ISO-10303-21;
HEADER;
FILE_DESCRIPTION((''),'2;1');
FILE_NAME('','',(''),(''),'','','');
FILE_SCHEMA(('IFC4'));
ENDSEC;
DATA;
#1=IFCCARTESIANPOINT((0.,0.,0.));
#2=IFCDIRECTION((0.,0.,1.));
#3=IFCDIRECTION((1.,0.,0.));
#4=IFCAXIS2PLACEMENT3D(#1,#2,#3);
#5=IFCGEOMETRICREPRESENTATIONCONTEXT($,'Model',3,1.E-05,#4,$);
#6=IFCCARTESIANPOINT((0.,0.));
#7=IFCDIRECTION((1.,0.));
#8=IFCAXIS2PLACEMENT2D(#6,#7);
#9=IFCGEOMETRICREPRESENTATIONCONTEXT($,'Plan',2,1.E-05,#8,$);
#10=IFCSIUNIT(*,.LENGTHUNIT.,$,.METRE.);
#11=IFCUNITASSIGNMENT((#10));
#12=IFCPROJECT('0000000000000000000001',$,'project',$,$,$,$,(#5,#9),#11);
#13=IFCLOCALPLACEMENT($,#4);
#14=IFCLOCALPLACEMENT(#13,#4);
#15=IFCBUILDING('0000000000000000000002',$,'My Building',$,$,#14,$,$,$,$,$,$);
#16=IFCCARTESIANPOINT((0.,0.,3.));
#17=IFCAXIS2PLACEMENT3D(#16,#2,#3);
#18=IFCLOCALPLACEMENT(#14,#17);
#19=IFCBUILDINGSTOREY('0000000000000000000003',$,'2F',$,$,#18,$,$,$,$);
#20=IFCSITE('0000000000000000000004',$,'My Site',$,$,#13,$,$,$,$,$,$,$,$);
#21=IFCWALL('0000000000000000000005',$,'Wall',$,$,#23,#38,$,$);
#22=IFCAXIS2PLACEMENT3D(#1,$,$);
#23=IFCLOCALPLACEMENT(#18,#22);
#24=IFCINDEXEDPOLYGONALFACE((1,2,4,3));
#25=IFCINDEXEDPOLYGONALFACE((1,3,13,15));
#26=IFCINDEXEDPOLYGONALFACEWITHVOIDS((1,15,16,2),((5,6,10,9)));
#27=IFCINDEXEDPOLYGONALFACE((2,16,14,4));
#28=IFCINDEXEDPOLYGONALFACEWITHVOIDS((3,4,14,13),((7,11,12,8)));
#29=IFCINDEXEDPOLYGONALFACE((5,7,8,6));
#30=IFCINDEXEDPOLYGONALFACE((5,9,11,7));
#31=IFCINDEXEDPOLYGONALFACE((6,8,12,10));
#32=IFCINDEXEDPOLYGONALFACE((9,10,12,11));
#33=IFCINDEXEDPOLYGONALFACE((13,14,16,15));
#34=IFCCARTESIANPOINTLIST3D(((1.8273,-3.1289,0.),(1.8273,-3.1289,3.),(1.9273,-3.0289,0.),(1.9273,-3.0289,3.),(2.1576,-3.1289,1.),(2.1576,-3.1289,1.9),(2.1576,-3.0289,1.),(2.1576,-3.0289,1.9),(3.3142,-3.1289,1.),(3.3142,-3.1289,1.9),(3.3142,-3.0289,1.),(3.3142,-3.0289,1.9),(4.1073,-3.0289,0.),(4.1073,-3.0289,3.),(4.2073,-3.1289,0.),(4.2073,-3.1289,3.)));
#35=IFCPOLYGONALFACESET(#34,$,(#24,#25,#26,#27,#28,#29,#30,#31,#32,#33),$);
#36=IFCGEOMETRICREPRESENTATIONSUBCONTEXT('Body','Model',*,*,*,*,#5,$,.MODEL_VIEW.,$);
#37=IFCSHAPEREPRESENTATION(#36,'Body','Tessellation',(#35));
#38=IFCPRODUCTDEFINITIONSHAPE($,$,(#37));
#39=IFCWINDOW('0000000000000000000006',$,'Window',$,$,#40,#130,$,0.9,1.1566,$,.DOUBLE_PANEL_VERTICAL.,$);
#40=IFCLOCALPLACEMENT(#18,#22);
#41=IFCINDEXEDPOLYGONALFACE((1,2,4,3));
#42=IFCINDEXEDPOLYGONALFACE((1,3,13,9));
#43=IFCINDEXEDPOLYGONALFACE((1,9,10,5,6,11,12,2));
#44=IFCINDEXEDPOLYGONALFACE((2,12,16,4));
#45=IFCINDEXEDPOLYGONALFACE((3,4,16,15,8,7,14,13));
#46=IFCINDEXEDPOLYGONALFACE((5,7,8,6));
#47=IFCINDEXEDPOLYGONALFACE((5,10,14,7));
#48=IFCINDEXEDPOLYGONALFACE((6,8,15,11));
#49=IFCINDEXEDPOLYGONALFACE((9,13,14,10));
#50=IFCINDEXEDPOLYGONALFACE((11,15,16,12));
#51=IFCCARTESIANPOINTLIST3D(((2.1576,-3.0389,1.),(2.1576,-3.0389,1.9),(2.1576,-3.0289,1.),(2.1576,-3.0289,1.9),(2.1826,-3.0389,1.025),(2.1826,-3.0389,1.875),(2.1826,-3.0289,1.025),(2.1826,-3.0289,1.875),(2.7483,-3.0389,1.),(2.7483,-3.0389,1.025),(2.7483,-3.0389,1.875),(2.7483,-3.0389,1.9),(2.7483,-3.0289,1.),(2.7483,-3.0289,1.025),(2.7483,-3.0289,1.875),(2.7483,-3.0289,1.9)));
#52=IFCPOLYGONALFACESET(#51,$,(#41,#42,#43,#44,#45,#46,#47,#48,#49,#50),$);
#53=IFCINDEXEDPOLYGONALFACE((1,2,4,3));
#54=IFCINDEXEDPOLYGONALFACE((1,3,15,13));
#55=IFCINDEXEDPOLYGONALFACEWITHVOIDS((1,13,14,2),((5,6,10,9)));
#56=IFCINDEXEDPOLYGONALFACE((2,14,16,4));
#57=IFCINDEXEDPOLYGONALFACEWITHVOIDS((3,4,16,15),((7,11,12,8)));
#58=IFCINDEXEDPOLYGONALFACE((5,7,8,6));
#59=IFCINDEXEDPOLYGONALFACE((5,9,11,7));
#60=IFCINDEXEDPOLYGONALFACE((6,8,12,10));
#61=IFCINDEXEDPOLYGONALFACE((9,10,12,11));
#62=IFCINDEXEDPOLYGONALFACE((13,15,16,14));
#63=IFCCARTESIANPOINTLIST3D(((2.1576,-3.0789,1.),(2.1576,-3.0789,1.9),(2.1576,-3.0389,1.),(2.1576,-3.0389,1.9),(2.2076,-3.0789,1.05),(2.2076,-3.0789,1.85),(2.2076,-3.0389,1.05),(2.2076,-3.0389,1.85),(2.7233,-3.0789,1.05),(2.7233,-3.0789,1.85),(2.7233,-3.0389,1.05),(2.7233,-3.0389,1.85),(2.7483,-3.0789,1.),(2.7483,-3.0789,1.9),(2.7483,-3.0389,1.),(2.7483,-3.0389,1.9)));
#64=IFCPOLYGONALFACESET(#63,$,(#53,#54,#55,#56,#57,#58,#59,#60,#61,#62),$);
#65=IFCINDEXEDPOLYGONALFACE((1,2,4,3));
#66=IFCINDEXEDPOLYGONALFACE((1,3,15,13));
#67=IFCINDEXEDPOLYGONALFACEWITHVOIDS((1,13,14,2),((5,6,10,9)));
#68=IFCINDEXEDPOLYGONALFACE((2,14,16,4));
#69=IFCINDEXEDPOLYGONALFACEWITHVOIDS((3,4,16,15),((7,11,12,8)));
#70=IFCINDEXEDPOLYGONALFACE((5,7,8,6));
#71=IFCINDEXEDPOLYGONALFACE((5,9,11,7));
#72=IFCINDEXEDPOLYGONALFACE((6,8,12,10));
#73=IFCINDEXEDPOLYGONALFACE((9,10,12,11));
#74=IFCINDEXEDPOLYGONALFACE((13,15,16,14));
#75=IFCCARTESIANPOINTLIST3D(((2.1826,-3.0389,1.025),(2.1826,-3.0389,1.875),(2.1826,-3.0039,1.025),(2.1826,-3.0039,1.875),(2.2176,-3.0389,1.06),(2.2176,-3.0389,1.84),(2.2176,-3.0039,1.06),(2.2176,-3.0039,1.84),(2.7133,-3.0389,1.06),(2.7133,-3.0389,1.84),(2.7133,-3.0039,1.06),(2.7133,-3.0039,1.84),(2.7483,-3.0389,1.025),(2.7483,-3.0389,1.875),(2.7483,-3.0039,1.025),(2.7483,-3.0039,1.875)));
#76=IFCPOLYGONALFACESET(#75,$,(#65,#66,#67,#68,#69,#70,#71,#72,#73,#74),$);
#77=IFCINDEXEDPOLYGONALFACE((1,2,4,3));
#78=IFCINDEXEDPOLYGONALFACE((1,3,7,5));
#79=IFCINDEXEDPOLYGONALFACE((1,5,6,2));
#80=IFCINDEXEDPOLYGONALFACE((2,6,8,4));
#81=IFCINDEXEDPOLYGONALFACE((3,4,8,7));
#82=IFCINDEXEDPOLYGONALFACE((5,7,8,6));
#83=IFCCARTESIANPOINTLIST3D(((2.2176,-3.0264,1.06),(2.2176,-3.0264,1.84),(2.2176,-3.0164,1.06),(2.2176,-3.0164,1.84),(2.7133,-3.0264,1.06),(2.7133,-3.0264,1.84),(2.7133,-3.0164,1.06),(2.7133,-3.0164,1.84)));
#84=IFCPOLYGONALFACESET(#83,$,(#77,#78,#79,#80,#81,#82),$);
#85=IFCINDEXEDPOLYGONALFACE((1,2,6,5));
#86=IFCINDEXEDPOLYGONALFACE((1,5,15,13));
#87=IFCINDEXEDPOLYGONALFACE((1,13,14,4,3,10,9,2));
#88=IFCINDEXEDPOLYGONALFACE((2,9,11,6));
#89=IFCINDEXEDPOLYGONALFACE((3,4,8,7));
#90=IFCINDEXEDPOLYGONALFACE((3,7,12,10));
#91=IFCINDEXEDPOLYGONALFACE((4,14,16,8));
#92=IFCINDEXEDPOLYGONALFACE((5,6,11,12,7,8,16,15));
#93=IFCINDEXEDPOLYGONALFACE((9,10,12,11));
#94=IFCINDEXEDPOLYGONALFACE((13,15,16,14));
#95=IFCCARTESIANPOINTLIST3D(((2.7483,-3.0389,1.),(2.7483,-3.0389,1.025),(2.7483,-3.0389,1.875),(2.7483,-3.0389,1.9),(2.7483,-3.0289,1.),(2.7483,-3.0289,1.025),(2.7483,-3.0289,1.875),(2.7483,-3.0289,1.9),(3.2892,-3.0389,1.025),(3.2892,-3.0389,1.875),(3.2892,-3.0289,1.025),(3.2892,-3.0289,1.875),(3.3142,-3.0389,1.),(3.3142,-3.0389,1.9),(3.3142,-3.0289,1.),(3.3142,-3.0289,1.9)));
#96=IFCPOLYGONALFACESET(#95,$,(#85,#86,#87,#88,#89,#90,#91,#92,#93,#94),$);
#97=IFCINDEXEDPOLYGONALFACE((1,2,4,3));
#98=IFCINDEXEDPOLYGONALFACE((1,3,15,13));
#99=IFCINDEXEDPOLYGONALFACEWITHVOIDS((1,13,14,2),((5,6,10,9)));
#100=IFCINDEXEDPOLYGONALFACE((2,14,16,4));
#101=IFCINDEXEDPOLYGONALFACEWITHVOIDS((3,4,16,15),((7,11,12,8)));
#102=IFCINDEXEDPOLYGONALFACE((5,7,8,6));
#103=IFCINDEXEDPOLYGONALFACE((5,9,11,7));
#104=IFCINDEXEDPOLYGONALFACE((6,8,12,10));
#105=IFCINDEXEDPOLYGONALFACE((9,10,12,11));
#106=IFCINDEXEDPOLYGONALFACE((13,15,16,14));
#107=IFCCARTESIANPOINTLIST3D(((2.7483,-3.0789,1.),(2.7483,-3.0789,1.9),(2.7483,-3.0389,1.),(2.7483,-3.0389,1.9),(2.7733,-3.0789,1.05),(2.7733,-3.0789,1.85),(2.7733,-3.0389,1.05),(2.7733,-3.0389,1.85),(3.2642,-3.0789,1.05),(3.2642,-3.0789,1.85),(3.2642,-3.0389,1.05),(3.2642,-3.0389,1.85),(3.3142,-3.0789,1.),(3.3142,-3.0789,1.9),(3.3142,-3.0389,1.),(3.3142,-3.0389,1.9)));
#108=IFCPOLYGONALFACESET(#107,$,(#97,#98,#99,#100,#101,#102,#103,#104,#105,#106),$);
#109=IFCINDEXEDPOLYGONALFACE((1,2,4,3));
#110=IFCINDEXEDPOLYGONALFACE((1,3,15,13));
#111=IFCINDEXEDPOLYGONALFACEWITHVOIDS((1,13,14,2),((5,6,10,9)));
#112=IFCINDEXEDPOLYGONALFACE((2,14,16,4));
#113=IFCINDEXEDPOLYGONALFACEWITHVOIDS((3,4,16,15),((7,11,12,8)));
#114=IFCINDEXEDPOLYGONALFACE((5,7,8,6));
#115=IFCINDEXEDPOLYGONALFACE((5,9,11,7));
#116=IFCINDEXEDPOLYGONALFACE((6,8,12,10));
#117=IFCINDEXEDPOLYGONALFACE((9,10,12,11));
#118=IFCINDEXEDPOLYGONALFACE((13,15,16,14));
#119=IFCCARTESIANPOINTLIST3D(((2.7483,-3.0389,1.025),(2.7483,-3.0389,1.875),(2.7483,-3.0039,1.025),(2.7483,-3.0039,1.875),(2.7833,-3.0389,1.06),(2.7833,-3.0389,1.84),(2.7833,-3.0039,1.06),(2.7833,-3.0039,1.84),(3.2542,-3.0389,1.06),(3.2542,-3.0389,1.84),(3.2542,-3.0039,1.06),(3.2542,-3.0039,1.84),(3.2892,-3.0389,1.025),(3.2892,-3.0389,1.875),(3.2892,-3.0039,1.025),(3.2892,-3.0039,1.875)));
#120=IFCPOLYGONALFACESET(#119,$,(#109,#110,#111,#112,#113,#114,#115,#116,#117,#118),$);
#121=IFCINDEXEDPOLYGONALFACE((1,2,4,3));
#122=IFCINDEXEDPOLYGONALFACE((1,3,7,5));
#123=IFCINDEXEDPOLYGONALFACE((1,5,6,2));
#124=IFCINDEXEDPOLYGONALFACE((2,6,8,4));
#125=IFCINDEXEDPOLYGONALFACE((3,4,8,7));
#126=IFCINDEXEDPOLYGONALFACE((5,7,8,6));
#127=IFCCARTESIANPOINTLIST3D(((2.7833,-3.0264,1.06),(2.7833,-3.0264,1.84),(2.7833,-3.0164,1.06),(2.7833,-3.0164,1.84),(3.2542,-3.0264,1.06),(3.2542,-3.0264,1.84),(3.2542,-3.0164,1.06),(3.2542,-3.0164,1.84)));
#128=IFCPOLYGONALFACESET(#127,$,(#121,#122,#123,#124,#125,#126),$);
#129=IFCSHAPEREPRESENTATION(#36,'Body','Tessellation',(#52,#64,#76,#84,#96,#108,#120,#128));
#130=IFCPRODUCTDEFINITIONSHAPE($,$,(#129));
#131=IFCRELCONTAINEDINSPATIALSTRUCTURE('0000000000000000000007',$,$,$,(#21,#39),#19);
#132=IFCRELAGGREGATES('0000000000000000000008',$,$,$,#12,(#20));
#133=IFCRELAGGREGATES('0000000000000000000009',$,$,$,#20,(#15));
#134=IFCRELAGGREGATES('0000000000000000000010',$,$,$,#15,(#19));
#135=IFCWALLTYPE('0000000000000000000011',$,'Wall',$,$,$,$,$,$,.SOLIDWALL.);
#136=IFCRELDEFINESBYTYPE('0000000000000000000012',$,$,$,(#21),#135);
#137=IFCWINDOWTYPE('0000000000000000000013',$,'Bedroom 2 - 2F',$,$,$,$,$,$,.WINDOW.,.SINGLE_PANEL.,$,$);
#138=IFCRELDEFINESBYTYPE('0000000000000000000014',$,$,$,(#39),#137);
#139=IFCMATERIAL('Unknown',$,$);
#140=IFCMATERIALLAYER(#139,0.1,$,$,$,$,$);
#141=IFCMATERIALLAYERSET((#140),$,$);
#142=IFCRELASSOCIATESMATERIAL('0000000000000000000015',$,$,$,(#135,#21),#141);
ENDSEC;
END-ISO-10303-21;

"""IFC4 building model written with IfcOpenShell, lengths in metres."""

from ifc_helpers import new_model, entity, si_unit, frame, origin_with_axes, origin_2d_with_axis, place, context, subcontext, project, spatial, line, indexed_curve, outline, extrude, shape, source, transform, mapped, material, layer, layer_set, layer_usage, type_object, type_shapes, element, fill, save


model = new_model("IFC4")

# Units and contexts
model_context = context("Model", 3, precision=1e-05, world=origin_with_axes())
plan_context = context("Plan", 2, precision=1e-05, world=origin_2d_with_axis())
body_context_1 = subcontext(model_context, "Body", "Model", "MODEL_VIEW")
body_context_2 = subcontext(plan_context, "Body", "Plan", "PLAN_VIEW")
ifc_project = project(units=[si_unit("LENGTHUNIT", "METRE")], contexts=[model_context, plan_context])

# Site, building, storey
site_placement = place(None, origin_with_axes())
site = spatial("IfcSite", under=ifc_project, at=site_placement, Name="My Site")
building_placement = place(site_placement, origin_with_axes())
building = spatial("IfcBuilding", under=site, at=building_placement, Name="My Building")
storey_placement = place(building_placement, frame((0.0, 0.0, 3.0), z_axis=(0.0, 0.0, 1.0), x_axis=(1.0, 0.0, 0.0)))
storey = spatial("IfcBuildingStorey", under=building, at=storey_placement, Name="2F")

# Shared definitions
ifc_material = material(Name="Unknown")

# Shared definitions
ifc_layer_1 = layer(ifc_material, 0.1)
ifc_layer_set_1 = layer_set([ifc_layer_1])
wall_type_1 = type_object("IfcWallType", Name="Wall", PredefinedType="SOLIDWALL", material=ifc_layer_set_1)

# Wall, opening, window
ifc_layer_usage_1 = layer_usage(ifc_layer_set_1, "AXIS2", "POSITIVE", 0.0)
wall_1_placement = place(storey_placement, frame((1.8273, -3.1289, 0.0), z_axis=(0.0, 0.0, 1.0), x_axis=(1.0, 0.0, 0.0)))
wall_1 = element("IfcWall", 1, at=wall_1_placement, inside=storey, type_object=wall_type_1, material=ifc_layer_usage_1, Name="Wall", context=body_context_1, shape_type="SweptSolid", body=[
    extrude(outline(indexed_curve([(0.0, 0.0), (0.1, 0.1), (2.28, 0.1), (2.38, 0.0)], segments=[line(1, 2, 3, 4, 1)])), origin_with_axes(), (0.0, 0.0, 1.0), 3.0),
])
shared_shape_1 = source(origin_with_axes(), body_context_1, "Body", "SweptSolid", [
    extrude(outline(indexed_curve([(0.0, 0.0), (1.1566, 0.0), (1.1566, 0.9), (0.0, 0.9)], segments=[line(1, 2, 3, 4, 1)])), frame((0.0, -0.6, 0.0), z_axis=(0.0, -1.0, 0.0), x_axis=(1.0, 0.0, 0.0)), (0.0, 0.0, -1.0), 1.2),
])
opening_1_placement = place(wall_1_placement, frame((0.3303, 0.0, 1.0), z_axis=(0.0, 0.0, 1.0), x_axis=(1.0, 0.0, 0.0)))
opening_1 = element("IfcOpeningElement", 2, at=opening_1_placement, cuts=wall_1, PredefinedType="OPENING", context=body_context_1, shape_type="MappedRepresentation", body=[
    mapped(shared_shape_1, transform((0.0, 0.0, 0.0), x_axis=(1.0, 0.0, 0.0), y_axis=(0.0, 1.0, 0.0), z_axis=(0.0, 0.0, 1.0), scale=1.0)),
])
window_type = type_object("IfcWindowType", Name="Bedroom 2 - 2F", PartitioningType="SINGLE_PANEL", PredefinedType="WINDOW")
shared_shape_2 = source(origin_with_axes(), body_context_1, "Body", "SweptSolid", [
    extrude(outline(indexed_curve([(0.5908, 0.0), (0.0, 0.0), (0.0, 0.9), (0.5908, 0.9), (0.5908, 0.875), (0.025, 0.875), (0.025, 0.025), (0.5908, 0.025)], segments=[line(1, 2, 3, 4, 5, 6, 7, 8, 1)])), frame((0.0, 0.09, 0.0), z_axis=(0.0, -1.0, 0.0), x_axis=(1.0, 0.0, 0.0)), (0.0, 0.0, -1.0), 0.01),
    extrude(outline(indexed_curve([(0.0, 0.0), (0.5908, 0.0), (0.5908, 0.9), (0.0, 0.9)], segments=[line(1, 2, 3, 4, 1)]), holes=[indexed_curve([(0.05, 0.05), (0.5658, 0.05), (0.5658, 0.85), (0.05, 0.85)], segments=[line(1, 2, 3, 4, 1)])]), frame((0.0, 0.05, 0.0), z_axis=(0.0, -1.0, 0.0), x_axis=(1.0, 0.0, 0.0)), (0.0, 0.0, -1.0), 0.04),
    extrude(outline(indexed_curve([(0.0, 0.0), (0.5658, 0.0), (0.5658, 0.85), (0.0, 0.85)], segments=[line(1, 2, 3, 4, 1)]), holes=[indexed_curve([(0.035, 0.035), (0.5308, 0.035), (0.5308, 0.815), (0.035, 0.815)], segments=[line(1, 2, 3, 4, 1)])]), frame((0.025, 0.09, 0.025), z_axis=(0.0, -1.0, 0.0), x_axis=(1.0, 0.0, 0.0)), (0.0, 0.0, -1.0), 0.035),
    extrude(outline(indexed_curve([(0.035, 0.035), (0.5308, 0.035), (0.5308, 0.815), (0.035, 0.815)], segments=[line(1, 2, 3, 4, 1)])), frame((0.025, 0.1025, 0.025), z_axis=(0.0, -1.0, 0.0), x_axis=(1.0, 0.0, 0.0)), (0.0, 0.0, -1.0), 0.01),
    extrude(outline(indexed_curve([(0.0, 0.9), (0.5659, 0.9), (0.5659, 0.0), (0.0, 0.0), (0.0, 0.025), (0.5409, 0.025), (0.5409, 0.875), (0.0, 0.875)], segments=[line(1, 2, 3, 4, 5, 6, 7, 8, 1)])), frame((0.5908, 0.09, 0.0), z_axis=(0.0, -1.0, 0.0), x_axis=(1.0, 0.0, 0.0)), (0.0, 0.0, -1.0), 0.01),
    extrude(outline(indexed_curve([(0.0, 0.0), (0.5659, 0.0), (0.5659, 0.9), (0.0, 0.9)], segments=[line(1, 2, 3, 4, 1)]), holes=[indexed_curve([(0.025, 0.05), (0.5159, 0.05), (0.5159, 0.85), (0.025, 0.85)], segments=[line(1, 2, 3, 4, 1)])]), frame((0.5908, 0.05, 0.0), z_axis=(0.0, -1.0, 0.0), x_axis=(1.0, 0.0, 0.0)), (0.0, 0.0, -1.0), 0.04),
    extrude(outline(indexed_curve([(0.0, 0.0), (0.5409, 0.0), (0.5409, 0.85), (0.0, 0.85)], segments=[line(1, 2, 3, 4, 1)]), holes=[indexed_curve([(0.035, 0.035), (0.5059, 0.035), (0.5059, 0.815), (0.035, 0.815)], segments=[line(1, 2, 3, 4, 1)])]), frame((0.5908, 0.09, 0.025), z_axis=(0.0, -1.0, 0.0), x_axis=(1.0, 0.0, 0.0)), (0.0, 0.0, -1.0), 0.035),
    extrude(outline(indexed_curve([(0.035, 0.035), (0.5059, 0.035), (0.5059, 0.815), (0.035, 0.815)], segments=[line(1, 2, 3, 4, 1)])), frame((0.5908, 0.1025, 0.025), z_axis=(0.0, -1.0, 0.0), x_axis=(1.0, 0.0, 0.0)), (0.0, 0.0, -1.0), 0.01),
])
shared_shape_3 = source(origin_with_axes(), body_context_2, "Body", "Curve2D", [
    entity("IfcIndexedPolyCurve", entity("IfcCartesianPointList2D", [[0.05, 0.05], [0.5658, 0.05]])),
    entity("IfcIndexedPolyCurve", entity("IfcCartesianPointList2D", [[0.0, 0.1], [0.025, 0.1], [0.025, 0.09], [0.05, 0.09], [0.05, 0.05], [0.0, 0.05]]), [entity("IfcLineIndex", [1, 2, 3, 4, 5, 6, 1])]),
    entity("IfcIndexedPolyCurve", entity("IfcCartesianPointList2D", [[0.5908, 0.1], [0.5908, 0.1], [0.5908, 0.09], [0.5658, 0.09], [0.5658, 0.05], [0.5908, 0.05]])),
    entity("IfcIndexedPolyCurve", entity("IfcCartesianPointList2D", [[0.025, 0.09], [0.06, 0.09], [0.06, 0.125], [0.025, 0.125]]), [entity("IfcLineIndex", [1, 2, 3, 4, 1])]),
    entity("IfcIndexedPolyCurve", entity("IfcCartesianPointList2D", [[0.5908, 0.09], [0.5558, 0.09], [0.5558, 0.125], [0.5908, 0.125]]), [entity("IfcLineIndex", [1, 2, 3, 4, 1])]),
    entity("IfcIndexedPolyCurve", entity("IfcCartesianPointList2D", [[0.06, 0.09], [0.5558, 0.09]])),
    entity("IfcIndexedPolyCurve", entity("IfcCartesianPointList2D", [[0.06, 0.125], [0.5558, 0.125]])),
    entity("IfcIndexedPolyCurve", entity("IfcCartesianPointList2D", [[0.06, 0.1075], [0.5558, 0.1075]])),
    entity("IfcIndexedPolyCurve", entity("IfcCartesianPointList2D", [[0.6158, 0.05], [1.1066, 0.05]])),
    entity("IfcIndexedPolyCurve", entity("IfcCartesianPointList2D", [[0.5908, 0.1], [0.5908, 0.1], [0.5908, 0.09], [0.6158, 0.09], [0.6158, 0.05], [0.5908, 0.05]])),
    entity("IfcIndexedPolyCurve", entity("IfcCartesianPointList2D", [[1.1566, 0.1], [1.1316, 0.1], [1.1316, 0.09], [1.1066, 0.09], [1.1066, 0.05], [1.1566, 0.05]]), [entity("IfcLineIndex", [1, 2, 3, 4, 5, 6, 1])]),
    entity("IfcIndexedPolyCurve", entity("IfcCartesianPointList2D", [[0.5908, 0.09], [0.6258, 0.09], [0.6258, 0.125], [0.5908, 0.125]]), [entity("IfcLineIndex", [1, 2, 3, 4, 1])]),
    entity("IfcIndexedPolyCurve", entity("IfcCartesianPointList2D", [[1.1316, 0.09], [1.0966, 0.09], [1.0966, 0.125], [1.1316, 0.125]]), [entity("IfcLineIndex", [1, 2, 3, 4, 1])]),
    entity("IfcIndexedPolyCurve", entity("IfcCartesianPointList2D", [[0.6258, 0.09], [1.0966, 0.09]])),
    entity("IfcIndexedPolyCurve", entity("IfcCartesianPointList2D", [[0.6258, 0.125], [1.0966, 0.125]])),
    entity("IfcIndexedPolyCurve", entity("IfcCartesianPointList2D", [[0.6258, 0.1075], [1.0966, 0.1075]])),
])
type_shapes(window_type, [shared_shape_2, shared_shape_3])
window_placement = place(opening_1_placement, origin_with_axes())
window = element("IfcWindow", 3, at=window_placement, inside=storey, type_object=window_type, Name="Window", OverallHeight=0.9, OverallWidth=1.1566, PartitioningType="DOUBLE_PANEL_VERTICAL", shapes=[
    shape(body_context_1, "Body", "MappedRepresentation", [mapped(shared_shape_2, transform((0.0, 0.0, 0.0), x_axis=(1.0, 0.0, 0.0), y_axis=(0.0, 1.0, 0.0), z_axis=(0.0, 0.0, 1.0), scale=1.0))]),
    shape(body_context_2, "Body", "MappedRepresentation", [mapped(shared_shape_3, transform((0.0, 0.0, 0.0), x_axis=(1.0, 0.0, 0.0), y_axis=(0.0, 1.0, 0.0), z_axis=(0.0, 0.0, 1.0), scale=1.0))]),
])
fill(opening_1, window)

save(model, "model.ifc")
